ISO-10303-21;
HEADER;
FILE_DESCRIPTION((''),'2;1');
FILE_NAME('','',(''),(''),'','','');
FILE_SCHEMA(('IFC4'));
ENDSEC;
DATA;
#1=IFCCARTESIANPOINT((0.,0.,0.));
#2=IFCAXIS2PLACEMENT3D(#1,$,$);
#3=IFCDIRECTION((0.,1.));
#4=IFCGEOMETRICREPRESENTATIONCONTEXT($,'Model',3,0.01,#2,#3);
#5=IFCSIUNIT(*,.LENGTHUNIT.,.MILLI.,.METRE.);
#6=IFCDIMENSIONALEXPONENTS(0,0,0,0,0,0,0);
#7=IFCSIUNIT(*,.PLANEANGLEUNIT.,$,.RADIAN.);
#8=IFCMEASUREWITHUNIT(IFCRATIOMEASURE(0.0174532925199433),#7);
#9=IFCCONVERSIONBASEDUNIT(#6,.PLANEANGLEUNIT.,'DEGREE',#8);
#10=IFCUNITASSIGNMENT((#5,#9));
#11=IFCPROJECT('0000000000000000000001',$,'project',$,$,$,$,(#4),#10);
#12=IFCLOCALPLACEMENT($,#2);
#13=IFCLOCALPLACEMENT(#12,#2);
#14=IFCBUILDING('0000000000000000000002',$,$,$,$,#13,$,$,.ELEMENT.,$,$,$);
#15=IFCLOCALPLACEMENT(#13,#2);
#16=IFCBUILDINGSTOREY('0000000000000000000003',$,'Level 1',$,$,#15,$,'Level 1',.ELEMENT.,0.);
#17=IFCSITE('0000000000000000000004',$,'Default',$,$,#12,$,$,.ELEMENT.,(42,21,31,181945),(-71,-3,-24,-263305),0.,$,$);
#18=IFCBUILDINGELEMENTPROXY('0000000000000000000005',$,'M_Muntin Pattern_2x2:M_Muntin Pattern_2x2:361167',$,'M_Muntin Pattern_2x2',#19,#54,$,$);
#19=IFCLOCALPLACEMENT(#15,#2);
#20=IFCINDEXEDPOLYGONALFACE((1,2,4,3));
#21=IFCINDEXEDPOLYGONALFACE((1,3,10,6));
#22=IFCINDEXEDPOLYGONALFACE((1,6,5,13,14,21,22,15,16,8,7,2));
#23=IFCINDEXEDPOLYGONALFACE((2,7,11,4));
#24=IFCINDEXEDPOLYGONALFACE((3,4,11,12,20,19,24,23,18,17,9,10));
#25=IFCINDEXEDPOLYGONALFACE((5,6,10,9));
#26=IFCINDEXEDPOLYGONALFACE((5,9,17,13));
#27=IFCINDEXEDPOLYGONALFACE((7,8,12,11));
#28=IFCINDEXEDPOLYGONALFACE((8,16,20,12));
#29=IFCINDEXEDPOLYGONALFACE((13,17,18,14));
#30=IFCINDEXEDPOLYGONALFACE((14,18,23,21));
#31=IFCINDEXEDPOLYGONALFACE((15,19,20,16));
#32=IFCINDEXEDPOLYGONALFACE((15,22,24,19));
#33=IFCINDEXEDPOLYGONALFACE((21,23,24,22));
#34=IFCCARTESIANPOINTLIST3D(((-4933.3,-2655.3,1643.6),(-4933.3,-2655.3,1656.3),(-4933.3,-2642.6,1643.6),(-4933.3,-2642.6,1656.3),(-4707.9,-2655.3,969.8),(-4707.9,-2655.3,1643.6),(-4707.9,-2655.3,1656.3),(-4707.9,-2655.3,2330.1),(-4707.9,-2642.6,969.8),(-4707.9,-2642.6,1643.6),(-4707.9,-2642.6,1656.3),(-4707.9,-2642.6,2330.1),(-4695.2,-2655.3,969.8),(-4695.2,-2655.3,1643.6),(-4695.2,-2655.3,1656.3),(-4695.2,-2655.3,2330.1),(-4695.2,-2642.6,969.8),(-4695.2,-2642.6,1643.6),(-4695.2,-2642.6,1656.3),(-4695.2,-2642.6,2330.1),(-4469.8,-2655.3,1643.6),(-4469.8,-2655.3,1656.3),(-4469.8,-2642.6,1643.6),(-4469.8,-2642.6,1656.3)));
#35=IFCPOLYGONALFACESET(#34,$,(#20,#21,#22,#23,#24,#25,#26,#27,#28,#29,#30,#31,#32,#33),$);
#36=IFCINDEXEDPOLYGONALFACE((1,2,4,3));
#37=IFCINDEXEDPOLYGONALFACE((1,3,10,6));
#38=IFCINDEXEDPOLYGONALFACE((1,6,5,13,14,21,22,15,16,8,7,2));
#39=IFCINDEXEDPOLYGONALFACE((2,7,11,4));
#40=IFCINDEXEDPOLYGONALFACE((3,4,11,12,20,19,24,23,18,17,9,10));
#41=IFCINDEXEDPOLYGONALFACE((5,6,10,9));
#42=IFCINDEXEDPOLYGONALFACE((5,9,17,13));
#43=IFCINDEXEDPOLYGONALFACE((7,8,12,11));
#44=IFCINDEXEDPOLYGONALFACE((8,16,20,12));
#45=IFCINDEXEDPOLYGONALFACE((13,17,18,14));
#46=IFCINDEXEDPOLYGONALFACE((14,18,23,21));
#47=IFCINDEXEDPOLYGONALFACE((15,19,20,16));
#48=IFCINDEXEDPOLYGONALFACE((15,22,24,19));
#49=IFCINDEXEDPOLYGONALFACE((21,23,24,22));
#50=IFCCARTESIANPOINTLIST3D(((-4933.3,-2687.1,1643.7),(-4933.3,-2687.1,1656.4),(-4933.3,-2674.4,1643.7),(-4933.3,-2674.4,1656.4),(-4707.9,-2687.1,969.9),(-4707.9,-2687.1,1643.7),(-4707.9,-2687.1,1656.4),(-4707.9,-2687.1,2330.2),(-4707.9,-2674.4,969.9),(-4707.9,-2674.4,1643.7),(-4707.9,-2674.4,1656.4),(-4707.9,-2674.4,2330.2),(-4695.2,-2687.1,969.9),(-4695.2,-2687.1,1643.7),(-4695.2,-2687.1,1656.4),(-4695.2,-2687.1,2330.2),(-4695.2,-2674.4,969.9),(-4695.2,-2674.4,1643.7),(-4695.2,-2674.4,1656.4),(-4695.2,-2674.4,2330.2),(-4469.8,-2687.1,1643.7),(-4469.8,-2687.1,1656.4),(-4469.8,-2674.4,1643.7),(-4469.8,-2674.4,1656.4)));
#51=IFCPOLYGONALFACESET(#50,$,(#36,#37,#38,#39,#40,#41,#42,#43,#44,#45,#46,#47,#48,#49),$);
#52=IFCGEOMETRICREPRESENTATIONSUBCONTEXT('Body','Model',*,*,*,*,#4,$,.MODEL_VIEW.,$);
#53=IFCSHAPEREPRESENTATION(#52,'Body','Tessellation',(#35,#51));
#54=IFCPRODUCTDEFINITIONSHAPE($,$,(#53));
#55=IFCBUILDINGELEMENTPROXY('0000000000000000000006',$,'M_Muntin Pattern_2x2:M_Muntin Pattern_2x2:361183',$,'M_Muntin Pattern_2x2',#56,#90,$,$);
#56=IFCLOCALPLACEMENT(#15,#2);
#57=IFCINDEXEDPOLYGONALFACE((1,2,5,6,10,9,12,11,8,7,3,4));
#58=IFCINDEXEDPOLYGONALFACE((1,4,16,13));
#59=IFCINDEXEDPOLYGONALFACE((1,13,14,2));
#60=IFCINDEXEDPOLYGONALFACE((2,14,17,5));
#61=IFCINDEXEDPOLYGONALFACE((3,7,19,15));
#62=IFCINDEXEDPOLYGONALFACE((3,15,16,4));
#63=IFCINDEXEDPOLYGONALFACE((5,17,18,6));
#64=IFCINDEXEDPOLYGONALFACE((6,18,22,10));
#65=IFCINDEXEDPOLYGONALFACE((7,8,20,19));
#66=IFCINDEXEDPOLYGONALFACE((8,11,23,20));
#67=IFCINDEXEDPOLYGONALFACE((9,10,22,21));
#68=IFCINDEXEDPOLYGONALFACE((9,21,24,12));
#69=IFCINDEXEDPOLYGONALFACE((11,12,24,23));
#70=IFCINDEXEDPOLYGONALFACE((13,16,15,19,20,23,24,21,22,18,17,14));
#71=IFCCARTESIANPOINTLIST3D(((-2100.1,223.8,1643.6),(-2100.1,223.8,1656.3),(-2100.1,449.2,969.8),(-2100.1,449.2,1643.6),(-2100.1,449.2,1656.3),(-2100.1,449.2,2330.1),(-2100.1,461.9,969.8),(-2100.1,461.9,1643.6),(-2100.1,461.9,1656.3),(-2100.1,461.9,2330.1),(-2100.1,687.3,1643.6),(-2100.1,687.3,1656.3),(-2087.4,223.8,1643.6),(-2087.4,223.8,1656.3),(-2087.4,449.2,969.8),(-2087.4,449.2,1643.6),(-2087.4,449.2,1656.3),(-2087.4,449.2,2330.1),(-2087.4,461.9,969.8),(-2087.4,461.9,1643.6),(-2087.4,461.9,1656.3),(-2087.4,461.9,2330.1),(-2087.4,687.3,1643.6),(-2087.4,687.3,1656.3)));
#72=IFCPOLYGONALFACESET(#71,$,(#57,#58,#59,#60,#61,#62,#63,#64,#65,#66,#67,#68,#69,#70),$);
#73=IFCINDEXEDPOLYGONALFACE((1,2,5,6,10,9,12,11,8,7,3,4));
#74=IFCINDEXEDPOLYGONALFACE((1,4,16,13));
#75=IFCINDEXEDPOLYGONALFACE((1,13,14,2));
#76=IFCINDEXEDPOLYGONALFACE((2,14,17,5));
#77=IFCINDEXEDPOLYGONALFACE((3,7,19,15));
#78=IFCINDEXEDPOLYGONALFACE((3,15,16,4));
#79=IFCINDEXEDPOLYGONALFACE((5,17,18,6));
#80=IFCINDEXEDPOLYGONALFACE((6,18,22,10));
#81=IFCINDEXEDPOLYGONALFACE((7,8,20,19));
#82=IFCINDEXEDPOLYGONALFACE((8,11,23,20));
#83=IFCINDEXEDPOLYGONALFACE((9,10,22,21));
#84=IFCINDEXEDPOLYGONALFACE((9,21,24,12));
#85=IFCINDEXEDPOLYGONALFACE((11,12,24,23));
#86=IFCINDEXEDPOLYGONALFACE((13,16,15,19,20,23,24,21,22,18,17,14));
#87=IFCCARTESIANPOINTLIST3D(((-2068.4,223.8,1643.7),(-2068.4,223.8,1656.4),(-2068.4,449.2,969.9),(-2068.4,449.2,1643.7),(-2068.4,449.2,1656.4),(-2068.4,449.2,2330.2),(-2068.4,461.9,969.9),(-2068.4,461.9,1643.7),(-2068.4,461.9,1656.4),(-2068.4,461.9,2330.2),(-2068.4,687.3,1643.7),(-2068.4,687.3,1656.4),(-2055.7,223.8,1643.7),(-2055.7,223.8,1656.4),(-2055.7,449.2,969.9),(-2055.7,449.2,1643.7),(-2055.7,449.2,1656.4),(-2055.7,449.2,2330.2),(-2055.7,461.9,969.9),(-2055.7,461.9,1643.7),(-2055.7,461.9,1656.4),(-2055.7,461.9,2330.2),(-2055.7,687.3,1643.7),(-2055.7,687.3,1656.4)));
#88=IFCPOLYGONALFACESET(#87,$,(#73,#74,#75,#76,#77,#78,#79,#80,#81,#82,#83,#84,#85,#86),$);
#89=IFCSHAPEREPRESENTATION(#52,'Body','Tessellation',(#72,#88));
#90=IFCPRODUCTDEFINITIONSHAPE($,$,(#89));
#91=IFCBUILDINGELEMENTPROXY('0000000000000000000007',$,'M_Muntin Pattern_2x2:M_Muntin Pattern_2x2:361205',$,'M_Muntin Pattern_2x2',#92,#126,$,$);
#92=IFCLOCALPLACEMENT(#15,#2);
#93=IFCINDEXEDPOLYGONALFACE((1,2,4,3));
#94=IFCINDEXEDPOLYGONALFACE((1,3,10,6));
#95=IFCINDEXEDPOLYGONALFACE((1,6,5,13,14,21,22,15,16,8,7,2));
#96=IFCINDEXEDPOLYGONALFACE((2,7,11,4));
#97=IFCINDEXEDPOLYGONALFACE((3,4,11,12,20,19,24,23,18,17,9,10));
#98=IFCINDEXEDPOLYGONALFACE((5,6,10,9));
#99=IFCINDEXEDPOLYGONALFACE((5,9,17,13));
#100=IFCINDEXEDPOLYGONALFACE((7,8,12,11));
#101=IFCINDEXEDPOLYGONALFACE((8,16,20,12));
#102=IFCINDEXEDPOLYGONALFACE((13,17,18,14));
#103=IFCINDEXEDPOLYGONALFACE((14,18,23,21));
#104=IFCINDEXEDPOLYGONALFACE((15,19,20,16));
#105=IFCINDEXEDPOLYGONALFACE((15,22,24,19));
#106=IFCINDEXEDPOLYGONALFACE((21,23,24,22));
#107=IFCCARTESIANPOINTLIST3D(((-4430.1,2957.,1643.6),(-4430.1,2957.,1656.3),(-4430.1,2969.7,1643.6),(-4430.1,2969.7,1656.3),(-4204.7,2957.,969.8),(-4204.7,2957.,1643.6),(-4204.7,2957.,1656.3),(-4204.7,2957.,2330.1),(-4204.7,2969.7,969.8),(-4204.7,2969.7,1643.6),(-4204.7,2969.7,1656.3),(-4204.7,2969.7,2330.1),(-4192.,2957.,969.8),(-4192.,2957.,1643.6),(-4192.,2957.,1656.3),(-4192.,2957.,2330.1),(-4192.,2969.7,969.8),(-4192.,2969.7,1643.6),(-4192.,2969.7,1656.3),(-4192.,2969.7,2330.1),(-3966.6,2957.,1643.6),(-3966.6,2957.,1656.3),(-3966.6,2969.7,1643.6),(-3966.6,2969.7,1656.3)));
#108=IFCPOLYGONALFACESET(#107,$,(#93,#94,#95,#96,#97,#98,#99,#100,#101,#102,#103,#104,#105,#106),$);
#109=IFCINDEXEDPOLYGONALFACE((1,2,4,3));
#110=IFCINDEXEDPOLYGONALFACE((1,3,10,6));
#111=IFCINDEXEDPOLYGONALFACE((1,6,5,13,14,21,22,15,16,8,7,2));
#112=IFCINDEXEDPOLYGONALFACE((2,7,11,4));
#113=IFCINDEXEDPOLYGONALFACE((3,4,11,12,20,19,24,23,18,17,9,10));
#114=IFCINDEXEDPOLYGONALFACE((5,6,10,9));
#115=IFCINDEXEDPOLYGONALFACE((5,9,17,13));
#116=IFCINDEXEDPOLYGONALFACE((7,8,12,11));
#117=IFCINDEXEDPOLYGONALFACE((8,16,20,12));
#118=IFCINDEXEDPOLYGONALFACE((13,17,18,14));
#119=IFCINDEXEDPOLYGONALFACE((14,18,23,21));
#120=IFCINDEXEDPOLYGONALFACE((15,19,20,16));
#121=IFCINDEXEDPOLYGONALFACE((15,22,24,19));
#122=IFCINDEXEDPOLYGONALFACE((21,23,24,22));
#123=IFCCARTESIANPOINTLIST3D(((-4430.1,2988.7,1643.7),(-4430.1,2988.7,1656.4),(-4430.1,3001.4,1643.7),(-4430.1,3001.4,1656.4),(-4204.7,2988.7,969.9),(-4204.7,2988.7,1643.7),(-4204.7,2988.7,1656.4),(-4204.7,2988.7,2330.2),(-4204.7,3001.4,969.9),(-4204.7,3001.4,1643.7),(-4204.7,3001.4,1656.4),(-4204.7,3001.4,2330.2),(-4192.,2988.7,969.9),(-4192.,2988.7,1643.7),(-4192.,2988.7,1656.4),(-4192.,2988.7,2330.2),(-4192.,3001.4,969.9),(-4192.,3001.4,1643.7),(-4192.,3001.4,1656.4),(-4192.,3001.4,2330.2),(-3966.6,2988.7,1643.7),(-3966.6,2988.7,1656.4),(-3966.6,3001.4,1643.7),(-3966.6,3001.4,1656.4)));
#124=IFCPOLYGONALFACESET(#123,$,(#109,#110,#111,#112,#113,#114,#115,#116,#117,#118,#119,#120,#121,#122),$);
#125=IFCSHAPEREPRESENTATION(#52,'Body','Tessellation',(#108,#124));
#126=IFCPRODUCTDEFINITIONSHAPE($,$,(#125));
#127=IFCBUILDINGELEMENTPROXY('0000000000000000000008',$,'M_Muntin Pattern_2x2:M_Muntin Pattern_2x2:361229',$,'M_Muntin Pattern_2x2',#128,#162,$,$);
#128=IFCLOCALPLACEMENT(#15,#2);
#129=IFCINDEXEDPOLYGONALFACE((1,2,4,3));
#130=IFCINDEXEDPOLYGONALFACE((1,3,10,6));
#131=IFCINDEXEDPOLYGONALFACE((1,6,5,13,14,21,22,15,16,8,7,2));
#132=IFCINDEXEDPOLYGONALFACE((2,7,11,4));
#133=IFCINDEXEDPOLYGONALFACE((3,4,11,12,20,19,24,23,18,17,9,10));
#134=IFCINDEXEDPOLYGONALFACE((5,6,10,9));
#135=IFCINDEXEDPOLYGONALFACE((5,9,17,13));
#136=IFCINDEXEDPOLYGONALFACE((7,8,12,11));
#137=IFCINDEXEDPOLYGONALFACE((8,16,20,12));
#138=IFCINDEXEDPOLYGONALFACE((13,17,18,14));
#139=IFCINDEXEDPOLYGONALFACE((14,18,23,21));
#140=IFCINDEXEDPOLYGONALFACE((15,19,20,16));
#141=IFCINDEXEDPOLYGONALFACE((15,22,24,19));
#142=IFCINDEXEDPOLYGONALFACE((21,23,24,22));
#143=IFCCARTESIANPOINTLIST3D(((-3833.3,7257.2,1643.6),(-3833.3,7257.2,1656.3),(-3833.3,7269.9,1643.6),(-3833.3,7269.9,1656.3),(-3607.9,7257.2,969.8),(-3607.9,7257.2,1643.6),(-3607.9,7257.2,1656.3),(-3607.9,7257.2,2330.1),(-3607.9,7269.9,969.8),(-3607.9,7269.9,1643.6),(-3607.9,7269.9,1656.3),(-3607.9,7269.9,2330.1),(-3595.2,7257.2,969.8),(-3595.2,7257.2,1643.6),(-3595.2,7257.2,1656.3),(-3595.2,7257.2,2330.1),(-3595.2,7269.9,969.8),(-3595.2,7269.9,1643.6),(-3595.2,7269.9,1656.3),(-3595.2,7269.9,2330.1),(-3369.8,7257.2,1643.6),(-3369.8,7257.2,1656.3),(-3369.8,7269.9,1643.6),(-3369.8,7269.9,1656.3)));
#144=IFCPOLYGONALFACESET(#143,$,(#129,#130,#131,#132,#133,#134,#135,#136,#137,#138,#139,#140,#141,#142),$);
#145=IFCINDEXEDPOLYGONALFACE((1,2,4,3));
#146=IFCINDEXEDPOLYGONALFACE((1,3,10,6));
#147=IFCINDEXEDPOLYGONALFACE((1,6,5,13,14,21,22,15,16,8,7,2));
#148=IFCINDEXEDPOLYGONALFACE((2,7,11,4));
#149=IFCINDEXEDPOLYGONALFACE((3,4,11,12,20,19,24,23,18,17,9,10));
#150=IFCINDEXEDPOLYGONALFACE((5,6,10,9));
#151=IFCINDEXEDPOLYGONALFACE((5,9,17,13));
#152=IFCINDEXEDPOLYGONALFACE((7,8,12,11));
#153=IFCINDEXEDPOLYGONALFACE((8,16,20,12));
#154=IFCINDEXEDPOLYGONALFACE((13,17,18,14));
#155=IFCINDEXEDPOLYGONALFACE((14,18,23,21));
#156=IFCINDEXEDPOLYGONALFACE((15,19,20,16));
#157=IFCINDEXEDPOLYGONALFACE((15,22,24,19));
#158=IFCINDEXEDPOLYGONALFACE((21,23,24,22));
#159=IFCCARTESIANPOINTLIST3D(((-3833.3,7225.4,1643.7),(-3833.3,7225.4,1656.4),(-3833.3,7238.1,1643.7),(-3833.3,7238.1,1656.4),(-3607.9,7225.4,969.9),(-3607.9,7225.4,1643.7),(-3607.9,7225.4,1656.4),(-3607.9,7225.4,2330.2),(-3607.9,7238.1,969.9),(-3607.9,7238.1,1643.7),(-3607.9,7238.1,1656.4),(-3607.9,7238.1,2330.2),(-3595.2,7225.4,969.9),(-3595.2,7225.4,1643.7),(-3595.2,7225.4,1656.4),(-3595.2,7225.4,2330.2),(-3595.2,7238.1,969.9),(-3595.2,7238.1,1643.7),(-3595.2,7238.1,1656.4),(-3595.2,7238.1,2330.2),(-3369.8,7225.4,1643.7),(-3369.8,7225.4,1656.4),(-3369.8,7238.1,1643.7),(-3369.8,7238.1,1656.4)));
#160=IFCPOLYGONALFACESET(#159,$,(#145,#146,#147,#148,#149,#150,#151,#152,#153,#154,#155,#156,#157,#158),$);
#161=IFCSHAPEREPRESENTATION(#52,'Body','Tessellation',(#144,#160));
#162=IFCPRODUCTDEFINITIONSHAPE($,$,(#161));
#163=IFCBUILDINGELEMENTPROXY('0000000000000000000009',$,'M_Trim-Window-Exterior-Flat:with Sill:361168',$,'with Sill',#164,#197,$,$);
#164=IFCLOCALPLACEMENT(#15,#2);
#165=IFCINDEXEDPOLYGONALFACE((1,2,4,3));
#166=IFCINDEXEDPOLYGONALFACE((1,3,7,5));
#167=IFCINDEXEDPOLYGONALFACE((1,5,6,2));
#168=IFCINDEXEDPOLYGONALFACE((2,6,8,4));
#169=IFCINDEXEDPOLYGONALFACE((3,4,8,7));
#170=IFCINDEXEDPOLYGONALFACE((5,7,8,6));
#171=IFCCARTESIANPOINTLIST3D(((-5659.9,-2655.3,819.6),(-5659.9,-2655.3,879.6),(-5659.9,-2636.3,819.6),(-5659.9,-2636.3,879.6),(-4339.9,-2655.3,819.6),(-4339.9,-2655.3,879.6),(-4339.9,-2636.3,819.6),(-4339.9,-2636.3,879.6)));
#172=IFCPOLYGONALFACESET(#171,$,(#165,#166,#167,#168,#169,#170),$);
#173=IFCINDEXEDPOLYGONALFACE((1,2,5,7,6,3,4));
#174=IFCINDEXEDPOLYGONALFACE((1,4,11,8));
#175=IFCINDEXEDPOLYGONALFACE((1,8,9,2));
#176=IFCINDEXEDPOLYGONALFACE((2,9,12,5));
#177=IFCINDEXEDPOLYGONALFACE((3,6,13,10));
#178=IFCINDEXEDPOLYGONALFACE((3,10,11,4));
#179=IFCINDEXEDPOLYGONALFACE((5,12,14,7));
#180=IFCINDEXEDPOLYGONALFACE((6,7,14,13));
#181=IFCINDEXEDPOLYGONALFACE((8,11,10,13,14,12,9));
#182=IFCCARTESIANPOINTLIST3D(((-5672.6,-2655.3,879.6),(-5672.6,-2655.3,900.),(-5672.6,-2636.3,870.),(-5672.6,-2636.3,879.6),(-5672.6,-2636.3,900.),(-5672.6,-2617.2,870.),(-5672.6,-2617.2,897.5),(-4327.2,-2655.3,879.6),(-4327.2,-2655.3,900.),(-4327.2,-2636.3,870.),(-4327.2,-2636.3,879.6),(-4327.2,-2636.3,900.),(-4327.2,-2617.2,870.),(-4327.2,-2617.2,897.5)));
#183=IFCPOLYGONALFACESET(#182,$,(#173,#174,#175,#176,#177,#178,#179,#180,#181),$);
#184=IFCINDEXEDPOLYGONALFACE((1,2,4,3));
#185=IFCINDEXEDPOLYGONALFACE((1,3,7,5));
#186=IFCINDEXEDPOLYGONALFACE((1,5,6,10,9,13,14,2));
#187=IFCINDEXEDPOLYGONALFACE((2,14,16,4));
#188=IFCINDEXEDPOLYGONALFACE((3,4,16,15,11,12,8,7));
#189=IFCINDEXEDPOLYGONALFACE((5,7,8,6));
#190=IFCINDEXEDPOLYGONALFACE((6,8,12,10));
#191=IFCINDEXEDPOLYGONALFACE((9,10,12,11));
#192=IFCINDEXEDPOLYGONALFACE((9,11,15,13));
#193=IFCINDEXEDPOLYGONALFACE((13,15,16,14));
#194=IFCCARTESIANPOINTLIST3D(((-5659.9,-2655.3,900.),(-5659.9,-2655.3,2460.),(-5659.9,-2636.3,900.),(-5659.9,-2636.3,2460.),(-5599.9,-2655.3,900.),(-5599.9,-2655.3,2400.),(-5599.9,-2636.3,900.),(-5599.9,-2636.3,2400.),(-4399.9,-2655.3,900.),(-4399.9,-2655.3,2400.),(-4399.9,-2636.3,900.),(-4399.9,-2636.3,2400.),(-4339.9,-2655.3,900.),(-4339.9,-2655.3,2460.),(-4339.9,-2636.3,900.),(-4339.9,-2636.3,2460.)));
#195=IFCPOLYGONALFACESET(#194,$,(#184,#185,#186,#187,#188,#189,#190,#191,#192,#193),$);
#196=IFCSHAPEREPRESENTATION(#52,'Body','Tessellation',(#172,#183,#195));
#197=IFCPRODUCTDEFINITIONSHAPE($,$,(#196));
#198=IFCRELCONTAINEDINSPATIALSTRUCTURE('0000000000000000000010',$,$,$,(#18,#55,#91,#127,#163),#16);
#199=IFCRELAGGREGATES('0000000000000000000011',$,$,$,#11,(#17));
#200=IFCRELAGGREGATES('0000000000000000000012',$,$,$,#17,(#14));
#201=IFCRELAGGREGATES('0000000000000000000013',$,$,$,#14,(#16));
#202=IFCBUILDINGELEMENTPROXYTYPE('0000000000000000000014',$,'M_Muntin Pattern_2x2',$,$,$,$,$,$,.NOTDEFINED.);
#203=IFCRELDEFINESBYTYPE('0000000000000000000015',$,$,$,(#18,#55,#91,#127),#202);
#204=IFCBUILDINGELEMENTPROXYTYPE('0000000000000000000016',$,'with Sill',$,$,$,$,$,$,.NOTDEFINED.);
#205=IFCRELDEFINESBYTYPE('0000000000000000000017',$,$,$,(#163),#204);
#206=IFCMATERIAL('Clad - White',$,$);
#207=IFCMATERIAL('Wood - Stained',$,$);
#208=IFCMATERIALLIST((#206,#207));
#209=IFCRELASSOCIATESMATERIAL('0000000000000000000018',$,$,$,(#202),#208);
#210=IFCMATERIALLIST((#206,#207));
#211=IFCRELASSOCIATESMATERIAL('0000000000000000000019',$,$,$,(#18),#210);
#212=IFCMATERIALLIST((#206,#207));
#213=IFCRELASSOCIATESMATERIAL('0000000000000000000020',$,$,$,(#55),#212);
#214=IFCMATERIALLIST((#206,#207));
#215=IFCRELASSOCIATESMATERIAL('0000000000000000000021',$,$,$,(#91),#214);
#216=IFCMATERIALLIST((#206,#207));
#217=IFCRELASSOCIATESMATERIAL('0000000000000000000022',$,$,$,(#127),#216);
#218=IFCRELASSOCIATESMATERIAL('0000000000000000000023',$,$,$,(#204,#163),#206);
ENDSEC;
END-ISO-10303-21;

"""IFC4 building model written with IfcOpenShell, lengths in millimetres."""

from ifc_helpers import new_model, entity, si_unit, converted_unit, direction, frame, frame_2d, origin, place, context, subcontext, project, spatial, polyline, rectangle, outline, extrude, source, transform, mapped, material, material_list, type_object, type_shapes, element, save


model = new_model("IFC4")

# Units and contexts
model_context = context("Model", 3, precision=0.01, world=origin(), true_north=direction((0.0, 1.0)))
body_context = subcontext(model_context, "Body", "Model", "MODEL_VIEW")
ifc_project = project(units=[si_unit("LENGTHUNIT", "METRE", prefix="MILLI"), converted_unit("PLANEANGLEUNIT", "DEGREE", entity("IfcRatioMeasure", 0.0174532925199433), si_unit("PLANEANGLEUNIT", "RADIAN"), dimensions=[0, 0, 0, 0, 0, 0, 0])], contexts=[model_context])

# Site, building, storey
site_placement = place(None, origin())
site = spatial("IfcSite", under=ifc_project, at=site_placement, Name="Default", CompositionType="ELEMENT", RefLatitude=(42, 21, 31, 181945), RefLongitude=(-71, -3, -24, -263305), RefElevation=0.0)
building_placement = place(site_placement, origin())
building = spatial("IfcBuilding", under=site, at=building_placement, CompositionType="ELEMENT")
storey_placement = place(building_placement, origin())
storey = spatial("IfcBuildingStorey", under=building, at=storey_placement, Name="Level 1", LongName="Level 1", CompositionType="ELEMENT", Elevation=0.0)

# Building element proxies
ifc_material_1 = material(Name="Clad - White")
ifc_material_2 = material(Name="Wood - Stained")
ifc_material_list_1 = material_list([ifc_material_1, ifc_material_2])
ifc_material_list_2 = material_list([ifc_material_1, ifc_material_2])
building_element_proxy_type_1 = type_object("IfcBuildingElementProxyType", Name="M_Muntin Pattern_2x2", PredefinedType="NOTDEFINED", material=ifc_material_list_2)
shared_shape_1 = source(origin(), body_context, "Body", "SweptSolid", [
    extrude(outline(polyline([(6.4, -6.4), (680.1, -6.4), (680.1, 6.3), (6.4, 6.3), (6.4, 231.7), (-6.3, 231.7), (-6.3, 6.3), (-680.2, 6.3), (-680.2, -6.4), (-6.3, -6.4), (-6.3, -231.7), (6.4, -231.7), (6.4, -6.4)])), frame((0.0, -22.2, 680.1), z_axis=(0.0, 1.0, 0.0), x_axis=(0.0, 0.0, 1.0)), (0.0, 0.0, 1.0), 12.7),
    extrude(outline(polyline([(6.4, -6.4), (680.1, -6.4), (680.1, 6.3), (6.4, 6.3), (6.4, 231.7), (-6.3, 231.7), (-6.3, 6.3), (-680.2, 6.3), (-680.2, -6.4), (-6.3, -6.4), (-6.3, -231.7), (6.4, -231.7), (6.4, -6.4)])), frame((0.0, 9.5, 680.2), z_axis=(0.0, 1.0, 0.0), x_axis=(0.0, 0.0, 1.0)), (0.0, 0.0, 1.0), 12.7),
])
type_shapes(building_element_proxy_type_1, [shared_shape_1])
proxy_1_placement = place(storey_placement, frame((-4701.5, -2664.9, 969.9), z_axis=(0.0, 0.0, 1.0), x_axis=(-1.0, 0.0, 0.0)))
element("IfcBuildingElementProxy", 1, at=proxy_1_placement, inside=storey, type_object=building_element_proxy_type_1, material=ifc_material_list_1, Name="M_Muntin Pattern_2x2:M_Muntin Pattern_2x2:361167", ObjectType="M_Muntin Pattern_2x2", context=body_context, shape_type="MappedRepresentation", body=[
    mapped(shared_shape_1, transform((0.0, 0.0, 0.0), scale=1.0)),
])
ifc_material_list_3 = material_list([ifc_material_1, ifc_material_2])
proxy_2_placement = place(storey_placement, frame((-2077.9, 455.6, 969.9), z_axis=(0.0, 0.0, 1.0), x_axis=(0.0, -1.0, 0.0)))
element("IfcBuildingElementProxy", 2, at=proxy_2_placement, inside=storey, type_object=building_element_proxy_type_1, material=ifc_material_list_3, Name="M_Muntin Pattern_2x2:M_Muntin Pattern_2x2:361183", ObjectType="M_Muntin Pattern_2x2", context=body_context, shape_type="MappedRepresentation", body=[
    mapped(shared_shape_1, transform((0.0, 0.0, 0.0), scale=1.0)),
])
ifc_material_list_4 = material_list([ifc_material_1, ifc_material_2])
proxy_3_placement = place(storey_placement, frame((-4198.4, 2979.2, 969.9)))
element("IfcBuildingElementProxy", 3, at=proxy_3_placement, inside=storey, type_object=building_element_proxy_type_1, material=ifc_material_list_4, Name="M_Muntin Pattern_2x2:M_Muntin Pattern_2x2:361205", ObjectType="M_Muntin Pattern_2x2", context=body_context, shape_type="MappedRepresentation", body=[
    mapped(shared_shape_1, transform((0.0, 0.0, 0.0), scale=1.0)),
])
ifc_material_list_5 = material_list([ifc_material_1, ifc_material_2])
proxy_4_placement = place(storey_placement, frame((-3601.5, 7247.6, 969.9), z_axis=(0.0, 0.0, 1.0), x_axis=(-1.0, 0.0, 0.0)))
element("IfcBuildingElementProxy", 4, at=proxy_4_placement, inside=storey, type_object=building_element_proxy_type_1, material=ifc_material_list_5, Name="M_Muntin Pattern_2x2:M_Muntin Pattern_2x2:361229", ObjectType="M_Muntin Pattern_2x2", context=body_context, shape_type="MappedRepresentation", body=[
    mapped(shared_shape_1, transform((0.0, 0.0, 0.0), scale=1.0)),
])
building_element_proxy_type_2 = type_object("IfcBuildingElementProxyType", Name="with Sill", PredefinedType="NOTDEFINED", material=ifc_material_1)
shared_shape_2 = source(origin(), body_context, "Body", "SweptSolid", [
    extrude(rectangle(XDim=1320.0, YDim=60.0, at=frame_2d((0.0, 0.0), x_axis=(1.0, 0.0))), frame((0.0, -1550.4, 0.0), z_axis=(0.0, 0.0, 1.0), x_axis=(-1.0, 0.0, 0.0)), (0.0, 0.0, 1.0), 19.1),
    extrude(outline(polyline([(-19.0, -15.2), (0.0, -15.2), (0.0, -5.7), (19.0, -5.7), (19.0, 14.8), (0.0, 14.8), (-19.0, 12.3), (-19.0, -15.2)])), frame((-672.7, -1514.8, 19.0), z_axis=(1.0, 0.0, 0.0), x_axis=(0.0, 0.0, -1.0)), (0.0, 0.0, 1.0), 1345.4),
    extrude(outline(polyline([(-795.0, -660.0), (765.0, -660.0), (765.0, -600.0), (-735.0, -600.0), (-735.0, 600.0), (765.0, 600.0), (765.0, 660.0), (-795.0, 660.0), (-795.0, -660.0)])), frame((0.0, -735.0, 0.0), z_axis=(0.0, 0.0, 1.0), x_axis=(0.0, -1.0, 0.0)), (0.0, 0.0, 1.0), 19.1),
])
type_shapes(building_element_proxy_type_2, [shared_shape_2])
for number, where, z_axis, x_axis, name in (
    (5, (-4999.9, -2655.3, 2400.0), (0.0, 1.0, 0.0), (-1.0, 0.0, 0.0), "M_Trim-Window-Exterior-Flat:with Sill:361168"),
):
    element("IfcBuildingElementProxy", number, at=place(storey_placement, frame(where, z_axis=z_axis, x_axis=x_axis)), inside=storey, type_object=building_element_proxy_type_2, material=ifc_material_1, Name=name, ObjectType="with Sill", context=body_context, shape_type="MappedRepresentation", body=[
        mapped(shared_shape_2, transform((0.0, 0.0, 0.0), scale=1.0)),
    ])

save(model, "model.ifc")
